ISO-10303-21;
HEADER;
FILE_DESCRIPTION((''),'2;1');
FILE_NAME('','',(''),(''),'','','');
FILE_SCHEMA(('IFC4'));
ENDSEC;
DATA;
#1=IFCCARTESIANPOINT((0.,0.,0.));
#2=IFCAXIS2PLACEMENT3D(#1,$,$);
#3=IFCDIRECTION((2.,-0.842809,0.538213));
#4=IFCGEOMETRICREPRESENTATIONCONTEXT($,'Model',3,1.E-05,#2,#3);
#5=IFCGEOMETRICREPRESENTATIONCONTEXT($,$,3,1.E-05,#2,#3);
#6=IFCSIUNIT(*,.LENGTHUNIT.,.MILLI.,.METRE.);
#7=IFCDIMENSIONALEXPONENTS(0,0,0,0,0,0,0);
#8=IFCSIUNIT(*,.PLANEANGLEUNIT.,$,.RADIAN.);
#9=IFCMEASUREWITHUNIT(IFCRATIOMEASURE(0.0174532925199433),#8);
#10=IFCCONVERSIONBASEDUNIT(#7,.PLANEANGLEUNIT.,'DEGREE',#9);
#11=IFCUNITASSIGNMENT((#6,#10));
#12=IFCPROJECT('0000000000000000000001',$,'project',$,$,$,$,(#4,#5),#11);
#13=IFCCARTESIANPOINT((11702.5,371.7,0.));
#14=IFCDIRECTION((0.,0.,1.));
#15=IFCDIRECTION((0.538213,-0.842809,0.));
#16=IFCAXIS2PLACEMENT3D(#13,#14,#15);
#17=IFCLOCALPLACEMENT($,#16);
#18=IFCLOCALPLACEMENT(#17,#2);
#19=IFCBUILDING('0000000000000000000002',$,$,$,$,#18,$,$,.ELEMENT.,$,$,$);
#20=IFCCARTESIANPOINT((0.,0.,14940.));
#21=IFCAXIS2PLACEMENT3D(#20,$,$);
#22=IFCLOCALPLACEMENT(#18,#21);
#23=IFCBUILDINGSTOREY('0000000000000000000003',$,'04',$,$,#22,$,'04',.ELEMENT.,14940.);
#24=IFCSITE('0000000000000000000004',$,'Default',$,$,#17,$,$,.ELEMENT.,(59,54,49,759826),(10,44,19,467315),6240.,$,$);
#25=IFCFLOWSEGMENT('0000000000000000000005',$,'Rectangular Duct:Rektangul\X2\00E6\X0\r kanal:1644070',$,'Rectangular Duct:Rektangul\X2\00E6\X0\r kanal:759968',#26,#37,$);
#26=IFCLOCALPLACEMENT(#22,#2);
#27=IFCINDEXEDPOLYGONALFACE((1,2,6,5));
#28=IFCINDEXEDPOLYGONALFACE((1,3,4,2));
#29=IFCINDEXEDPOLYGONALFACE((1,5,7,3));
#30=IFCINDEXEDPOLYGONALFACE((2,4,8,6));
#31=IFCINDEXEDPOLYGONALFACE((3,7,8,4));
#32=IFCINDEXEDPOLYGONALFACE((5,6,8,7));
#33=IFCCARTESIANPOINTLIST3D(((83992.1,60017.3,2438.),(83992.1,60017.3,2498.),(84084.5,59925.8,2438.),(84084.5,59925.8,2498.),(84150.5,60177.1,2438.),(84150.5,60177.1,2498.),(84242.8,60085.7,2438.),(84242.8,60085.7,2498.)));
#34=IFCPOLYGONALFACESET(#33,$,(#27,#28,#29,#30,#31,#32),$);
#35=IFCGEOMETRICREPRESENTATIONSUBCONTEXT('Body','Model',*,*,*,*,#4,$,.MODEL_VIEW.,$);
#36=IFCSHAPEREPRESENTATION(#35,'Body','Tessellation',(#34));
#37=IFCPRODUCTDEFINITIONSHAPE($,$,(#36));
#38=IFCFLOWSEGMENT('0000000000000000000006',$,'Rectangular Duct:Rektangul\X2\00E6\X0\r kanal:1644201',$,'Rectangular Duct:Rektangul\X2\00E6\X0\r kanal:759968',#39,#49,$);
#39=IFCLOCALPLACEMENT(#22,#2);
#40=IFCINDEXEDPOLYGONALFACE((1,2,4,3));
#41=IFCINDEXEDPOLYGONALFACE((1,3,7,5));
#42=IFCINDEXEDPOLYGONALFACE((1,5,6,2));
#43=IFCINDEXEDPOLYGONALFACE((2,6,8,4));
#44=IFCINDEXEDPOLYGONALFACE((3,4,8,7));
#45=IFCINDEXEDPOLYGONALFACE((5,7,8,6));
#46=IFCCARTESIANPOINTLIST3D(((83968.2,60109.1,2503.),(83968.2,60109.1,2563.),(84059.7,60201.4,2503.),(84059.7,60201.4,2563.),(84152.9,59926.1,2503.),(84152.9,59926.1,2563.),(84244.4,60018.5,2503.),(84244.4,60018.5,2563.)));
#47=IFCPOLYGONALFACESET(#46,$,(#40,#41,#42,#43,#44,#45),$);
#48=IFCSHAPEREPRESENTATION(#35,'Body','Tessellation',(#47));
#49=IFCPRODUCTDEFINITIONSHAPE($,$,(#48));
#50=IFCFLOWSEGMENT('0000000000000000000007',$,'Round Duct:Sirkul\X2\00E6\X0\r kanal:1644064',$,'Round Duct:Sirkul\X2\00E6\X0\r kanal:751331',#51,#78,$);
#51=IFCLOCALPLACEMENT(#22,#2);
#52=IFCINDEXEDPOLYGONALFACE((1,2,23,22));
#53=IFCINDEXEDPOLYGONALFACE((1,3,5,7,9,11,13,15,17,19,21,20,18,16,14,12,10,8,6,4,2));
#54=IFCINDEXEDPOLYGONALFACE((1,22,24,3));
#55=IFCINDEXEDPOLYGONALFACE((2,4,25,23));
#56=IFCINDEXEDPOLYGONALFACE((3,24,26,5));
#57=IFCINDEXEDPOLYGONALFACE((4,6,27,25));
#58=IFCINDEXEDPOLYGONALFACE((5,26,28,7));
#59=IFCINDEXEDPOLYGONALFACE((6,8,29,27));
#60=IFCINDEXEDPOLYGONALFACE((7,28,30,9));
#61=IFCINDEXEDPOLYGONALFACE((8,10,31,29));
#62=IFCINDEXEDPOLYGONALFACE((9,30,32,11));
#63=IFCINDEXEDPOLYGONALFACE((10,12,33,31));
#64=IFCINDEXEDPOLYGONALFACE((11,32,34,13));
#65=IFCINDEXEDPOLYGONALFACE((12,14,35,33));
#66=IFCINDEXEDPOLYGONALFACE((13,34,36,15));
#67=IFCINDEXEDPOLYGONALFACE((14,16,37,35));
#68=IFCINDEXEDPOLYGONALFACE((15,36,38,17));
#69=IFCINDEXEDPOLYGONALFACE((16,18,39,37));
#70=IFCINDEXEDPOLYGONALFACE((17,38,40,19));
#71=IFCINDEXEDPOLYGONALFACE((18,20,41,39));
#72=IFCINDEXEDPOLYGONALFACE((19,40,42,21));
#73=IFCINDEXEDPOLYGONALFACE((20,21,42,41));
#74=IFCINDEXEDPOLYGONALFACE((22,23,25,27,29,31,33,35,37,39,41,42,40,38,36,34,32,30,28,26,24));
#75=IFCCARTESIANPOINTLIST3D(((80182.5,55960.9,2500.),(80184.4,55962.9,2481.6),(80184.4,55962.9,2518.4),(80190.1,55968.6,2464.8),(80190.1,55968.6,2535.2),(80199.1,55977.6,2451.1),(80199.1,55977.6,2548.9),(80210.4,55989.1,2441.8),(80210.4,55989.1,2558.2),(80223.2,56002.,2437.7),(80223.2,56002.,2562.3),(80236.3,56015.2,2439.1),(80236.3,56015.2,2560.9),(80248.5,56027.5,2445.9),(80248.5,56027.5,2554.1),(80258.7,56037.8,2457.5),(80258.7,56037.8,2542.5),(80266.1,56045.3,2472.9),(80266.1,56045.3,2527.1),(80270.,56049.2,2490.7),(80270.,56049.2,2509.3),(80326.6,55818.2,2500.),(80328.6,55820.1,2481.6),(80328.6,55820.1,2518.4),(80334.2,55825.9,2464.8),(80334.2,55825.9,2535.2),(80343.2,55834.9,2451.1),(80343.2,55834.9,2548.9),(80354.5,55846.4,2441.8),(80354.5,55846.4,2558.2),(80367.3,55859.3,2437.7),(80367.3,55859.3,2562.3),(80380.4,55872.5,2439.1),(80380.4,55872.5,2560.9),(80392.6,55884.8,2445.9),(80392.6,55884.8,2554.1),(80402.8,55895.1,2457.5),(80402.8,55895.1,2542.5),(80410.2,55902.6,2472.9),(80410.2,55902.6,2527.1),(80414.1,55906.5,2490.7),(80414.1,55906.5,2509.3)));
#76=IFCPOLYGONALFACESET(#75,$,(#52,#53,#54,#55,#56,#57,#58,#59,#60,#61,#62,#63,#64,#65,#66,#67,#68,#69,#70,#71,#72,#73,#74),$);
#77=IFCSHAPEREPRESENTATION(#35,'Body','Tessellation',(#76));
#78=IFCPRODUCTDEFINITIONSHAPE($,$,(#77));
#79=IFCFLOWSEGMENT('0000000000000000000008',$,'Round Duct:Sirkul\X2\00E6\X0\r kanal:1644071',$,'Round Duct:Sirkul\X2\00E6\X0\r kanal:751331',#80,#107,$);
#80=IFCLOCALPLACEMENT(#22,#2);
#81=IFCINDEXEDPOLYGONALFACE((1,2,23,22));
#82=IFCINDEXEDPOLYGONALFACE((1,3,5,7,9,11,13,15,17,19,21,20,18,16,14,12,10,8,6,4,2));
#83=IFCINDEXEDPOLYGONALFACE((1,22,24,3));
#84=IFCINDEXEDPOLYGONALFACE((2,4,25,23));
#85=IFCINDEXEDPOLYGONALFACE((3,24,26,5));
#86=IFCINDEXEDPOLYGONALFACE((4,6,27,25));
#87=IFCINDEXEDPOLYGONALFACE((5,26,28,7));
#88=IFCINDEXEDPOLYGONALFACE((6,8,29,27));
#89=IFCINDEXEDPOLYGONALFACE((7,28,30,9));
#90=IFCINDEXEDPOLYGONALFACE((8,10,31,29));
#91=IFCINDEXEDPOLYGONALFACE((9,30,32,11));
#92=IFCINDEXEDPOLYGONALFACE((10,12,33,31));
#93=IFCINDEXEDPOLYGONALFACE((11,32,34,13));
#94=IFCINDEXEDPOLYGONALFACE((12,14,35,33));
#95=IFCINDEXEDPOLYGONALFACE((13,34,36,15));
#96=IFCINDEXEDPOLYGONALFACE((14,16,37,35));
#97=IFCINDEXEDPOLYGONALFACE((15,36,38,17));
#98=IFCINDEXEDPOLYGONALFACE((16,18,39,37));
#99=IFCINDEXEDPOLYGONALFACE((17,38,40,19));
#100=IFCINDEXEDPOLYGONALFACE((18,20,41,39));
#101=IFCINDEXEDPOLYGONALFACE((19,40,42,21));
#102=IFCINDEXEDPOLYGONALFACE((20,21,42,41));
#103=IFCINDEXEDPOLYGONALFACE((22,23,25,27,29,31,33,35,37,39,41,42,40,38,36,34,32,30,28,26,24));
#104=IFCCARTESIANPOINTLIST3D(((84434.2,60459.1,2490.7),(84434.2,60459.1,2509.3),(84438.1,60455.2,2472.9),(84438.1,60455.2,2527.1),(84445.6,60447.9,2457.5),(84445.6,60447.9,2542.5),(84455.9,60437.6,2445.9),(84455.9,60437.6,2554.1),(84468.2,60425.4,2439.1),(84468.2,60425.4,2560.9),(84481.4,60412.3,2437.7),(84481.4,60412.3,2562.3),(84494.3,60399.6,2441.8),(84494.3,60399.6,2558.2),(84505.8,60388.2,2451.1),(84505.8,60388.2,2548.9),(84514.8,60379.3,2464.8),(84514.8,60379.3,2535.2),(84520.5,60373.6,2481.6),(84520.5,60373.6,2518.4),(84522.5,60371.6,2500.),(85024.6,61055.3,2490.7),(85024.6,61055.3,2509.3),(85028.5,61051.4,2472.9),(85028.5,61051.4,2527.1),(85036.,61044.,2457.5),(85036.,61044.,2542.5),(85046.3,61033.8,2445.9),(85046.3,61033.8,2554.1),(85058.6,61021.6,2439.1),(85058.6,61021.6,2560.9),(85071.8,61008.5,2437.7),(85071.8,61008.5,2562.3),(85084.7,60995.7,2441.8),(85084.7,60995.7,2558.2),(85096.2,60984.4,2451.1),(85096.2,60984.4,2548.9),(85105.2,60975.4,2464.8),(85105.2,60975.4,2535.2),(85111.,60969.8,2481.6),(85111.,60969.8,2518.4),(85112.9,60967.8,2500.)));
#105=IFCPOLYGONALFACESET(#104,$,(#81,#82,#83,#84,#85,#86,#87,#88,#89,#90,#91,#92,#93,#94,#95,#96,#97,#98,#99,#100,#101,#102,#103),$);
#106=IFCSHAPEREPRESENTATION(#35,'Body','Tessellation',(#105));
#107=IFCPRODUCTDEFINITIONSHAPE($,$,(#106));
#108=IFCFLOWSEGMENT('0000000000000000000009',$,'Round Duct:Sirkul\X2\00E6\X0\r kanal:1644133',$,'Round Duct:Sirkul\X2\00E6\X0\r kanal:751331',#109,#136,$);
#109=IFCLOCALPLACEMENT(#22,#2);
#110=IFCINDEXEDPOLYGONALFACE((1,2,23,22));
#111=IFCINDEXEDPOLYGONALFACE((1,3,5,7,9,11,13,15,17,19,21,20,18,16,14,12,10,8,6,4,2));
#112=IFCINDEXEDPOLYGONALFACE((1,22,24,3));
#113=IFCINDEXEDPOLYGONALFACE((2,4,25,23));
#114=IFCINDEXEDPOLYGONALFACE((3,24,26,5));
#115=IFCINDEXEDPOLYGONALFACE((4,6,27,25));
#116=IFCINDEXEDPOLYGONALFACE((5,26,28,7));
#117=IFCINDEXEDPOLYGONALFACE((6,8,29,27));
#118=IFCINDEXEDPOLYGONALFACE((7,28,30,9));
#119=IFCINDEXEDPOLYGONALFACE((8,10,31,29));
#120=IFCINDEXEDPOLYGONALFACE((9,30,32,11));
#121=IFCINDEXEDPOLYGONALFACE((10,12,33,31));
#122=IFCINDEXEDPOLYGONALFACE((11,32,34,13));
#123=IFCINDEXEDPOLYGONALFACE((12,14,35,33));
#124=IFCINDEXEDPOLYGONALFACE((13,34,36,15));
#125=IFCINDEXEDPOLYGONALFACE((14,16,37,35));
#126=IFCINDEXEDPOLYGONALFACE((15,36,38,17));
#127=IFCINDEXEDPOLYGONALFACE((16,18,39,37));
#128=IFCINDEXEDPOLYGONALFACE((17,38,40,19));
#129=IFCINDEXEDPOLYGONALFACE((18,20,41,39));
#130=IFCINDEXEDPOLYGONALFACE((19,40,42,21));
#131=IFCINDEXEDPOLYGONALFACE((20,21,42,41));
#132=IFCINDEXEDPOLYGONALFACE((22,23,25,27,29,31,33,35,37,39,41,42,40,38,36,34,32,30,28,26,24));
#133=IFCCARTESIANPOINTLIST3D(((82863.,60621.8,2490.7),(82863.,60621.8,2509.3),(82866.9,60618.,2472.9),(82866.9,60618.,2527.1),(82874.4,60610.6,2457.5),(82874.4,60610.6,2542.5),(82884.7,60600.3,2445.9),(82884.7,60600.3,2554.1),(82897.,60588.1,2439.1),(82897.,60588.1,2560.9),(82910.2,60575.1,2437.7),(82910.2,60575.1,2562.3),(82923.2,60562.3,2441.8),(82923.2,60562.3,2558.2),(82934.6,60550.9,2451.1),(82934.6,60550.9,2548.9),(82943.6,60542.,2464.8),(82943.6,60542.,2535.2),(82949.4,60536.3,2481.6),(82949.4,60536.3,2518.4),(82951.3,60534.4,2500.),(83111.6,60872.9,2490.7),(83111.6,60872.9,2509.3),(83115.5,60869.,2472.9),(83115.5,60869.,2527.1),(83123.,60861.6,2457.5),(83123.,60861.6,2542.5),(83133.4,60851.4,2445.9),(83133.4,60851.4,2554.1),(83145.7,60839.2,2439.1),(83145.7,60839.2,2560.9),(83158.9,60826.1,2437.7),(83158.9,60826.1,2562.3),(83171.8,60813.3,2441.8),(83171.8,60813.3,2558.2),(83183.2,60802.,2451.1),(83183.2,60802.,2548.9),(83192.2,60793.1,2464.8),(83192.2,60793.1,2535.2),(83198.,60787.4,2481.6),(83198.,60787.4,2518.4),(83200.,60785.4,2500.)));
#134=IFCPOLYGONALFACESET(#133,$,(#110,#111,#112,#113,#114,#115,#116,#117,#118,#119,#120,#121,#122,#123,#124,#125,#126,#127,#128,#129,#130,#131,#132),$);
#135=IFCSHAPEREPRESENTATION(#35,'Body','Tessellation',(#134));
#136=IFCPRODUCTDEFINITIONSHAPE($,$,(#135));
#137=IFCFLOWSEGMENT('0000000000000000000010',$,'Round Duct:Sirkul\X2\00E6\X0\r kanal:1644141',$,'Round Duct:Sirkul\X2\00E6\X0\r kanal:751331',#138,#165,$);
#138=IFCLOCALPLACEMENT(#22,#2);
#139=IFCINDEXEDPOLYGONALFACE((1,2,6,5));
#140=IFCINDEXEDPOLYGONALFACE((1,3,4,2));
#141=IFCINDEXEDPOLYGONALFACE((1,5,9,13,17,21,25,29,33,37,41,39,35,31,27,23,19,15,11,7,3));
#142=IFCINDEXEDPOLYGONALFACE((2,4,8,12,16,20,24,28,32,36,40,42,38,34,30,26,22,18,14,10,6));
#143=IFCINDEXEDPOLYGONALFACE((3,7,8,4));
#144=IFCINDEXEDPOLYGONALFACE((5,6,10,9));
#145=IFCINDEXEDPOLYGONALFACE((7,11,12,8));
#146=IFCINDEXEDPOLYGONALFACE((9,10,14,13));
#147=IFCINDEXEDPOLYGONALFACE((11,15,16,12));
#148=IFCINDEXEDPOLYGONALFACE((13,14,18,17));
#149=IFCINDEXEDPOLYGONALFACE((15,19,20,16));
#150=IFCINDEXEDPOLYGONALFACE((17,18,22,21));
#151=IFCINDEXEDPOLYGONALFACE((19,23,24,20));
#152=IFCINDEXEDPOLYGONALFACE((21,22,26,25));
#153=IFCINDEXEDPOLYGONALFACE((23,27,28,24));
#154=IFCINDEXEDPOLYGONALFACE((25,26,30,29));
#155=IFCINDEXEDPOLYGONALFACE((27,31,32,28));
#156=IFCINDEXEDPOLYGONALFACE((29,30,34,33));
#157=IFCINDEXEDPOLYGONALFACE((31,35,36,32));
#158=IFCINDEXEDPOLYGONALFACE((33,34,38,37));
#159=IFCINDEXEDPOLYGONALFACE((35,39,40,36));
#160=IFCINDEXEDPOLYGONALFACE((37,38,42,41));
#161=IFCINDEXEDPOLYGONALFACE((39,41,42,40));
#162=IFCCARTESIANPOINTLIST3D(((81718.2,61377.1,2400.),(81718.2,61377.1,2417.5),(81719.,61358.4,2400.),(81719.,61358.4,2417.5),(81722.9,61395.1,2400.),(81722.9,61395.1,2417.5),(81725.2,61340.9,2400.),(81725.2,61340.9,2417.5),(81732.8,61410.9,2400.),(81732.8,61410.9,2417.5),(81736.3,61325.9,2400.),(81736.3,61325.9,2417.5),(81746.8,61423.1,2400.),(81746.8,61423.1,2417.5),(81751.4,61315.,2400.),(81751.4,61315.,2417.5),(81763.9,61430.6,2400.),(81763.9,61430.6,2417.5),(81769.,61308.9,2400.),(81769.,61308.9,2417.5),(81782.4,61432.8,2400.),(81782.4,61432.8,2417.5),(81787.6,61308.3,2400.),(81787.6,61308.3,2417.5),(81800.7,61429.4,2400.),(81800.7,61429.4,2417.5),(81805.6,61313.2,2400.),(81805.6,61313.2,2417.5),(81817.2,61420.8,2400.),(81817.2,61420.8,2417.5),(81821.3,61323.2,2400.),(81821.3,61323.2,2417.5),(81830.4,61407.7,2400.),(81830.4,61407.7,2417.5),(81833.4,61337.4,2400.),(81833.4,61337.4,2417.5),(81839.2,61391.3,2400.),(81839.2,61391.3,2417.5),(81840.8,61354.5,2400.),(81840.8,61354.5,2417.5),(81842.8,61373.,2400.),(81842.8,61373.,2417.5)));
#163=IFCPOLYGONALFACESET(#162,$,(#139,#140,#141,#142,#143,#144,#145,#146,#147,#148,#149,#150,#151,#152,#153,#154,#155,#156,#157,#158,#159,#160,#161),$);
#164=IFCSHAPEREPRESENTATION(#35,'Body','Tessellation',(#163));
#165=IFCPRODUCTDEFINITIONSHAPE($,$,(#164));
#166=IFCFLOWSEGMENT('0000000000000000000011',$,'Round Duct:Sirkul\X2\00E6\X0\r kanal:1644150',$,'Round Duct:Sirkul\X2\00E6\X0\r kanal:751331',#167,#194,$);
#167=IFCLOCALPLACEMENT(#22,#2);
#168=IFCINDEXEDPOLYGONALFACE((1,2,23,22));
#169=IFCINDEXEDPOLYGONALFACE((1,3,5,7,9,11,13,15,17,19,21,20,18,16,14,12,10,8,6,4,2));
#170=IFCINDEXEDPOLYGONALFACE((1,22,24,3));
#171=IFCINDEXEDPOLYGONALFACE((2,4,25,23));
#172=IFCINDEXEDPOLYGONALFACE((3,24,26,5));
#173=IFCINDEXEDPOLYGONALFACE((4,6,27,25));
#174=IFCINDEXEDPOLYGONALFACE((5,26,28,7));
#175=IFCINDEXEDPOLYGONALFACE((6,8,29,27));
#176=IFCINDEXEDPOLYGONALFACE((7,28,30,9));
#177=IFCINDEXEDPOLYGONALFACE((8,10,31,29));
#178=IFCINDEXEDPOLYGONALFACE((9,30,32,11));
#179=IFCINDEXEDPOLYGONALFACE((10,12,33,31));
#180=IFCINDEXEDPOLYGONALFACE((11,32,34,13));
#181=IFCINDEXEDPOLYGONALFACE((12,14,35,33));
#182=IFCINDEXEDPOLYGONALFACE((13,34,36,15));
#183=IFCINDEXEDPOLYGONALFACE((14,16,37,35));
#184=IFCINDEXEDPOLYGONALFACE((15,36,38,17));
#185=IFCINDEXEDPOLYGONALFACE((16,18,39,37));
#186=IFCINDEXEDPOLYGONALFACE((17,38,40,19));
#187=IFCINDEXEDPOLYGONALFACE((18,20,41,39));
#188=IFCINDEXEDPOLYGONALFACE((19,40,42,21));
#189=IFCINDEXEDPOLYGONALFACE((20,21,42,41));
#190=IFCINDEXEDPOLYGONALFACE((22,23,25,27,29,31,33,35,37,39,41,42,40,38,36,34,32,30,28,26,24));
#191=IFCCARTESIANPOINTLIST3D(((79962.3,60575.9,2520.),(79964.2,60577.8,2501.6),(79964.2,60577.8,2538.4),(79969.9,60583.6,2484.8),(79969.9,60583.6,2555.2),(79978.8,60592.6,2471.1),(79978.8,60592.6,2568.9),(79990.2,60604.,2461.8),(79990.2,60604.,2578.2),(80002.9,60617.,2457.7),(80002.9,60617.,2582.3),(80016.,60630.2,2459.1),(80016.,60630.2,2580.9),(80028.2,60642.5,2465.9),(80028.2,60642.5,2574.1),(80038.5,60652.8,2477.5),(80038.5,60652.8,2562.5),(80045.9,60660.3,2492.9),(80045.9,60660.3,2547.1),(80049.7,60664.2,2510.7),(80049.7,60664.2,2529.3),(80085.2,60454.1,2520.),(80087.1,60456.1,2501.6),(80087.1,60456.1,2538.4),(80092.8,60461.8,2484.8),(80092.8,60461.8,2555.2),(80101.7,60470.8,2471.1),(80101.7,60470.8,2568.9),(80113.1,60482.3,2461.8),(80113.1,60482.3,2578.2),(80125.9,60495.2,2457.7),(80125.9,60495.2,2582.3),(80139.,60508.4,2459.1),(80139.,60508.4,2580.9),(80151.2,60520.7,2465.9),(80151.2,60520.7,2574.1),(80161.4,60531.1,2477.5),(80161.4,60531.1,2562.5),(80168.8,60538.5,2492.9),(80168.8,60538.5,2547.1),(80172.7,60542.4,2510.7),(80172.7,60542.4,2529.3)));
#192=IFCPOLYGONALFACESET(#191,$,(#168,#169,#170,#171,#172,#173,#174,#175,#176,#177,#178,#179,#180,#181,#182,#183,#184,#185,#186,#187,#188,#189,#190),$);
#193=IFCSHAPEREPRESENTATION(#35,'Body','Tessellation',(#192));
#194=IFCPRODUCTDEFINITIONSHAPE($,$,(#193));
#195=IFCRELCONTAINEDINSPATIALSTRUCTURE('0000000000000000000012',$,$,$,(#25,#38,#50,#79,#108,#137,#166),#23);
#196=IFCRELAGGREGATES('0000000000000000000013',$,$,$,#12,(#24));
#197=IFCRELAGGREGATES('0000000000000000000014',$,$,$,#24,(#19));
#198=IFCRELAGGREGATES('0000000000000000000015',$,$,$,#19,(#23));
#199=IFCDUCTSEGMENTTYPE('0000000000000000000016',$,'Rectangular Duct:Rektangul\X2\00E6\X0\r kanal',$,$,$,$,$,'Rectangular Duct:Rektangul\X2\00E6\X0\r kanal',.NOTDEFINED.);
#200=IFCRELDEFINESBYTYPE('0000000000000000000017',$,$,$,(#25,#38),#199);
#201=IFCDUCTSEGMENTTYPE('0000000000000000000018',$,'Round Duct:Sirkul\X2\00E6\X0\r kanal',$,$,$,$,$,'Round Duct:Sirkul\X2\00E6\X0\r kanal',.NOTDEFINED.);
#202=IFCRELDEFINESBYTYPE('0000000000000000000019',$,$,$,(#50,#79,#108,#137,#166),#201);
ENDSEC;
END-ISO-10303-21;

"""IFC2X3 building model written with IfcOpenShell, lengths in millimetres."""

from ifc_helpers import new_model, entity, si_unit, converted_unit, direction, frame, frame_2d, origin, origin_2d_with_axis, place, context, subcontext, project, spatial, rectangle, circle, extrude, type_object, element, save


model = new_model("IFC2X3")

# Units and contexts
model_context = context("Model", 3, precision=1e-05, world=origin(), true_north=direction((2.0, -0.842809, 0.538213)))
context_of_model = context(None, 3, precision=1e-05, world=origin(), true_north=direction((2.0, -0.842809, 0.538213)))
body_context = subcontext(model_context, "Body", "Model", "MODEL_VIEW")
ifc_project = project(units=[si_unit("LENGTHUNIT", "METRE", prefix="MILLI"), converted_unit("PLANEANGLEUNIT", "DEGREE", entity("IfcRatioMeasure", 0.0174532925199433), si_unit("PLANEANGLEUNIT", "RADIAN"), dimensions=[0, 0, 0, 0, 0, 0, 0])], contexts=[model_context, context_of_model])

# Site, building, storey
site_placement = place(None, frame((11702.5, 371.7, 0.0), z_axis=(0.0, 0.0, 1.0), x_axis=(0.538213, -0.842809, 0.0)))
site = spatial("IfcSite", under=ifc_project, at=site_placement, Name="Default", CompositionType="ELEMENT", RefLatitude=(59, 54, 49, 759826), RefLongitude=(10, 44, 19, 467315), RefElevation=6240.0)
building_placement = place(site_placement, origin())
building = spatial("IfcBuilding", under=site, at=building_placement, CompositionType="ELEMENT")
storey_placement = place(building_placement, frame((0.0, 0.0, 14940.0)))
storey = spatial("IfcBuildingStorey", under=building, at=storey_placement, Name="04", LongName="04", CompositionType="ELEMENT", Elevation=14940.0)

# Flow segments
duct_segment_type_1 = type_object("IfcDuctSegmentType", Name="Rectangular Duct:Rektangulær kanal", ElementType="Rectangular Duct:Rektangulær kanal", PredefinedType="NOTDEFINED")
flow_segment_1_placement = place(storey_placement, origin())
element("IfcFlowSegment", 1, at=flow_segment_1_placement, inside=storey, type_object=duct_segment_type_1, Name="Rectangular Duct:Rektangulær kanal:1644070", ObjectType="Rectangular Duct:Rektangulær kanal:759968", context=body_context, shape_type="SweptSolid", body=[
    extrude(rectangle(XDim=225.0, YDim=130.0, at=frame_2d((0.0, 0.0), x_axis=(1.0, 0.0))), frame((84117.5, 60051.5, 2438.0), z_axis=(0.0, 0.0, 1.0), x_axis=(-0.703669, -0.710528, 0.0)), (0.0, 0.0, 1.0), 60.0),
])
flow_segment_2_placement = place(storey_placement, origin())
element("IfcFlowSegment", 2, at=flow_segment_2_placement, inside=storey, type_object=duct_segment_type_1, Name="Rectangular Duct:Rektangulær kanal:1644201", ObjectType="Rectangular Duct:Rektangulær kanal:759968", context=body_context, shape_type="SweptSolid", body=[
    extrude(rectangle(XDim=260.0, YDim=130.0, at=frame_2d((0.0, 0.0), x_axis=(1.0, 0.0))), frame((84106.3, 60063.8, 2503.0), z_axis=(0.0, 0.0, 1.0), x_axis=(0.710528, -0.703669, 0.0)), (0.0, 0.0, 1.0), 60.0),
])
duct_segment_type_2 = type_object("IfcDuctSegmentType", Name="Round Duct:Sirkulær kanal", ElementType="Round Duct:Sirkulær kanal", PredefinedType="NOTDEFINED")
flow_segment_3_placement = place(storey_placement, origin())
element("IfcFlowSegment", 3, at=flow_segment_3_placement, inside=storey, type_object=duct_segment_type_2, Name="Round Duct:Sirkulær kanal:1644064", ObjectType="Round Duct:Sirkulær kanal:751331", context=body_context, shape_type="SweptSolid", body=[
    extrude(circle(Radius=62.5, at=origin_2d_with_axis()), frame((80370.6, 55862.6, 2500.0), z_axis=(-0.710528, 0.703669, 0.0), x_axis=(-0.703669, -0.710528, 0.0)), (0.0, 0.0, 1.0), 202.8),
])
flow_segment_4_placement = place(storey_placement, origin())
element("IfcFlowSegment", 4, at=flow_segment_4_placement, inside=storey, type_object=duct_segment_type_2, Name="Round Duct:Sirkulær kanal:1644071", ObjectType="Round Duct:Sirkulær kanal:751331", context=body_context, shape_type="SweptSolid", body=[
    extrude(circle(Radius=62.5, at=origin_2d_with_axis()), frame((84478.1, 60415.6, 2500.0), z_axis=(0.703669, 0.710528, 0.0), x_axis=(0.710528, -0.703669, 0.0)), (0.0, 0.0, 1.0), 839.0),
])
flow_segment_5_placement = place(storey_placement, origin())
element("IfcFlowSegment", 5, at=flow_segment_5_placement, inside=storey, type_object=duct_segment_type_2, Name="Round Duct:Sirkulær kanal:1644133", ObjectType="Round Duct:Sirkulær kanal:751331", context=body_context, shape_type="SweptSolid", body=[
    extrude(circle(Radius=62.5, at=origin_2d_with_axis()), frame((82906.9, 60578.3, 2500.0), z_axis=(0.703669, 0.710528, 0.0), x_axis=(0.710528, -0.703669, 0.0)), (0.0, 0.0, 1.0), 353.3),
])
flow_segment_6_placement = place(storey_placement, origin())
element("IfcFlowSegment", 6, at=flow_segment_6_placement, inside=storey, type_object=duct_segment_type_2, Name="Round Duct:Sirkulær kanal:1644141", ObjectType="Round Duct:Sirkulær kanal:751331", context=body_context, shape_type="SweptSolid", body=[
    extrude(circle(Radius=62.5, at=frame_2d((0.0, 0.0), x_axis=(1.0, 0.0))), frame((81780.3, 61370.4, 2400.0), z_axis=(0.0, 0.0, 1.0), x_axis=(-0.703669, -0.710528, 0.0)), (0.0, 0.0, 1.0), 17.5),
])
flow_segment_7_placement = place(storey_placement, origin())
element("IfcFlowSegment", 7, at=flow_segment_7_placement, inside=storey, type_object=duct_segment_type_2, Name="Round Duct:Sirkulær kanal:1644150", ObjectType="Round Duct:Sirkulær kanal:751331", context=body_context, shape_type="SweptSolid", body=[
    extrude(circle(Radius=62.5, at=origin_2d_with_axis()), frame((80006.2, 60620.3, 2520.0), z_axis=(0.710528, -0.703669, 0.0), x_axis=(-0.703669, -0.710528, 0.0)), (0.0, 0.0, 1.0), 173.0),
])

save(model, "model.ifc")
